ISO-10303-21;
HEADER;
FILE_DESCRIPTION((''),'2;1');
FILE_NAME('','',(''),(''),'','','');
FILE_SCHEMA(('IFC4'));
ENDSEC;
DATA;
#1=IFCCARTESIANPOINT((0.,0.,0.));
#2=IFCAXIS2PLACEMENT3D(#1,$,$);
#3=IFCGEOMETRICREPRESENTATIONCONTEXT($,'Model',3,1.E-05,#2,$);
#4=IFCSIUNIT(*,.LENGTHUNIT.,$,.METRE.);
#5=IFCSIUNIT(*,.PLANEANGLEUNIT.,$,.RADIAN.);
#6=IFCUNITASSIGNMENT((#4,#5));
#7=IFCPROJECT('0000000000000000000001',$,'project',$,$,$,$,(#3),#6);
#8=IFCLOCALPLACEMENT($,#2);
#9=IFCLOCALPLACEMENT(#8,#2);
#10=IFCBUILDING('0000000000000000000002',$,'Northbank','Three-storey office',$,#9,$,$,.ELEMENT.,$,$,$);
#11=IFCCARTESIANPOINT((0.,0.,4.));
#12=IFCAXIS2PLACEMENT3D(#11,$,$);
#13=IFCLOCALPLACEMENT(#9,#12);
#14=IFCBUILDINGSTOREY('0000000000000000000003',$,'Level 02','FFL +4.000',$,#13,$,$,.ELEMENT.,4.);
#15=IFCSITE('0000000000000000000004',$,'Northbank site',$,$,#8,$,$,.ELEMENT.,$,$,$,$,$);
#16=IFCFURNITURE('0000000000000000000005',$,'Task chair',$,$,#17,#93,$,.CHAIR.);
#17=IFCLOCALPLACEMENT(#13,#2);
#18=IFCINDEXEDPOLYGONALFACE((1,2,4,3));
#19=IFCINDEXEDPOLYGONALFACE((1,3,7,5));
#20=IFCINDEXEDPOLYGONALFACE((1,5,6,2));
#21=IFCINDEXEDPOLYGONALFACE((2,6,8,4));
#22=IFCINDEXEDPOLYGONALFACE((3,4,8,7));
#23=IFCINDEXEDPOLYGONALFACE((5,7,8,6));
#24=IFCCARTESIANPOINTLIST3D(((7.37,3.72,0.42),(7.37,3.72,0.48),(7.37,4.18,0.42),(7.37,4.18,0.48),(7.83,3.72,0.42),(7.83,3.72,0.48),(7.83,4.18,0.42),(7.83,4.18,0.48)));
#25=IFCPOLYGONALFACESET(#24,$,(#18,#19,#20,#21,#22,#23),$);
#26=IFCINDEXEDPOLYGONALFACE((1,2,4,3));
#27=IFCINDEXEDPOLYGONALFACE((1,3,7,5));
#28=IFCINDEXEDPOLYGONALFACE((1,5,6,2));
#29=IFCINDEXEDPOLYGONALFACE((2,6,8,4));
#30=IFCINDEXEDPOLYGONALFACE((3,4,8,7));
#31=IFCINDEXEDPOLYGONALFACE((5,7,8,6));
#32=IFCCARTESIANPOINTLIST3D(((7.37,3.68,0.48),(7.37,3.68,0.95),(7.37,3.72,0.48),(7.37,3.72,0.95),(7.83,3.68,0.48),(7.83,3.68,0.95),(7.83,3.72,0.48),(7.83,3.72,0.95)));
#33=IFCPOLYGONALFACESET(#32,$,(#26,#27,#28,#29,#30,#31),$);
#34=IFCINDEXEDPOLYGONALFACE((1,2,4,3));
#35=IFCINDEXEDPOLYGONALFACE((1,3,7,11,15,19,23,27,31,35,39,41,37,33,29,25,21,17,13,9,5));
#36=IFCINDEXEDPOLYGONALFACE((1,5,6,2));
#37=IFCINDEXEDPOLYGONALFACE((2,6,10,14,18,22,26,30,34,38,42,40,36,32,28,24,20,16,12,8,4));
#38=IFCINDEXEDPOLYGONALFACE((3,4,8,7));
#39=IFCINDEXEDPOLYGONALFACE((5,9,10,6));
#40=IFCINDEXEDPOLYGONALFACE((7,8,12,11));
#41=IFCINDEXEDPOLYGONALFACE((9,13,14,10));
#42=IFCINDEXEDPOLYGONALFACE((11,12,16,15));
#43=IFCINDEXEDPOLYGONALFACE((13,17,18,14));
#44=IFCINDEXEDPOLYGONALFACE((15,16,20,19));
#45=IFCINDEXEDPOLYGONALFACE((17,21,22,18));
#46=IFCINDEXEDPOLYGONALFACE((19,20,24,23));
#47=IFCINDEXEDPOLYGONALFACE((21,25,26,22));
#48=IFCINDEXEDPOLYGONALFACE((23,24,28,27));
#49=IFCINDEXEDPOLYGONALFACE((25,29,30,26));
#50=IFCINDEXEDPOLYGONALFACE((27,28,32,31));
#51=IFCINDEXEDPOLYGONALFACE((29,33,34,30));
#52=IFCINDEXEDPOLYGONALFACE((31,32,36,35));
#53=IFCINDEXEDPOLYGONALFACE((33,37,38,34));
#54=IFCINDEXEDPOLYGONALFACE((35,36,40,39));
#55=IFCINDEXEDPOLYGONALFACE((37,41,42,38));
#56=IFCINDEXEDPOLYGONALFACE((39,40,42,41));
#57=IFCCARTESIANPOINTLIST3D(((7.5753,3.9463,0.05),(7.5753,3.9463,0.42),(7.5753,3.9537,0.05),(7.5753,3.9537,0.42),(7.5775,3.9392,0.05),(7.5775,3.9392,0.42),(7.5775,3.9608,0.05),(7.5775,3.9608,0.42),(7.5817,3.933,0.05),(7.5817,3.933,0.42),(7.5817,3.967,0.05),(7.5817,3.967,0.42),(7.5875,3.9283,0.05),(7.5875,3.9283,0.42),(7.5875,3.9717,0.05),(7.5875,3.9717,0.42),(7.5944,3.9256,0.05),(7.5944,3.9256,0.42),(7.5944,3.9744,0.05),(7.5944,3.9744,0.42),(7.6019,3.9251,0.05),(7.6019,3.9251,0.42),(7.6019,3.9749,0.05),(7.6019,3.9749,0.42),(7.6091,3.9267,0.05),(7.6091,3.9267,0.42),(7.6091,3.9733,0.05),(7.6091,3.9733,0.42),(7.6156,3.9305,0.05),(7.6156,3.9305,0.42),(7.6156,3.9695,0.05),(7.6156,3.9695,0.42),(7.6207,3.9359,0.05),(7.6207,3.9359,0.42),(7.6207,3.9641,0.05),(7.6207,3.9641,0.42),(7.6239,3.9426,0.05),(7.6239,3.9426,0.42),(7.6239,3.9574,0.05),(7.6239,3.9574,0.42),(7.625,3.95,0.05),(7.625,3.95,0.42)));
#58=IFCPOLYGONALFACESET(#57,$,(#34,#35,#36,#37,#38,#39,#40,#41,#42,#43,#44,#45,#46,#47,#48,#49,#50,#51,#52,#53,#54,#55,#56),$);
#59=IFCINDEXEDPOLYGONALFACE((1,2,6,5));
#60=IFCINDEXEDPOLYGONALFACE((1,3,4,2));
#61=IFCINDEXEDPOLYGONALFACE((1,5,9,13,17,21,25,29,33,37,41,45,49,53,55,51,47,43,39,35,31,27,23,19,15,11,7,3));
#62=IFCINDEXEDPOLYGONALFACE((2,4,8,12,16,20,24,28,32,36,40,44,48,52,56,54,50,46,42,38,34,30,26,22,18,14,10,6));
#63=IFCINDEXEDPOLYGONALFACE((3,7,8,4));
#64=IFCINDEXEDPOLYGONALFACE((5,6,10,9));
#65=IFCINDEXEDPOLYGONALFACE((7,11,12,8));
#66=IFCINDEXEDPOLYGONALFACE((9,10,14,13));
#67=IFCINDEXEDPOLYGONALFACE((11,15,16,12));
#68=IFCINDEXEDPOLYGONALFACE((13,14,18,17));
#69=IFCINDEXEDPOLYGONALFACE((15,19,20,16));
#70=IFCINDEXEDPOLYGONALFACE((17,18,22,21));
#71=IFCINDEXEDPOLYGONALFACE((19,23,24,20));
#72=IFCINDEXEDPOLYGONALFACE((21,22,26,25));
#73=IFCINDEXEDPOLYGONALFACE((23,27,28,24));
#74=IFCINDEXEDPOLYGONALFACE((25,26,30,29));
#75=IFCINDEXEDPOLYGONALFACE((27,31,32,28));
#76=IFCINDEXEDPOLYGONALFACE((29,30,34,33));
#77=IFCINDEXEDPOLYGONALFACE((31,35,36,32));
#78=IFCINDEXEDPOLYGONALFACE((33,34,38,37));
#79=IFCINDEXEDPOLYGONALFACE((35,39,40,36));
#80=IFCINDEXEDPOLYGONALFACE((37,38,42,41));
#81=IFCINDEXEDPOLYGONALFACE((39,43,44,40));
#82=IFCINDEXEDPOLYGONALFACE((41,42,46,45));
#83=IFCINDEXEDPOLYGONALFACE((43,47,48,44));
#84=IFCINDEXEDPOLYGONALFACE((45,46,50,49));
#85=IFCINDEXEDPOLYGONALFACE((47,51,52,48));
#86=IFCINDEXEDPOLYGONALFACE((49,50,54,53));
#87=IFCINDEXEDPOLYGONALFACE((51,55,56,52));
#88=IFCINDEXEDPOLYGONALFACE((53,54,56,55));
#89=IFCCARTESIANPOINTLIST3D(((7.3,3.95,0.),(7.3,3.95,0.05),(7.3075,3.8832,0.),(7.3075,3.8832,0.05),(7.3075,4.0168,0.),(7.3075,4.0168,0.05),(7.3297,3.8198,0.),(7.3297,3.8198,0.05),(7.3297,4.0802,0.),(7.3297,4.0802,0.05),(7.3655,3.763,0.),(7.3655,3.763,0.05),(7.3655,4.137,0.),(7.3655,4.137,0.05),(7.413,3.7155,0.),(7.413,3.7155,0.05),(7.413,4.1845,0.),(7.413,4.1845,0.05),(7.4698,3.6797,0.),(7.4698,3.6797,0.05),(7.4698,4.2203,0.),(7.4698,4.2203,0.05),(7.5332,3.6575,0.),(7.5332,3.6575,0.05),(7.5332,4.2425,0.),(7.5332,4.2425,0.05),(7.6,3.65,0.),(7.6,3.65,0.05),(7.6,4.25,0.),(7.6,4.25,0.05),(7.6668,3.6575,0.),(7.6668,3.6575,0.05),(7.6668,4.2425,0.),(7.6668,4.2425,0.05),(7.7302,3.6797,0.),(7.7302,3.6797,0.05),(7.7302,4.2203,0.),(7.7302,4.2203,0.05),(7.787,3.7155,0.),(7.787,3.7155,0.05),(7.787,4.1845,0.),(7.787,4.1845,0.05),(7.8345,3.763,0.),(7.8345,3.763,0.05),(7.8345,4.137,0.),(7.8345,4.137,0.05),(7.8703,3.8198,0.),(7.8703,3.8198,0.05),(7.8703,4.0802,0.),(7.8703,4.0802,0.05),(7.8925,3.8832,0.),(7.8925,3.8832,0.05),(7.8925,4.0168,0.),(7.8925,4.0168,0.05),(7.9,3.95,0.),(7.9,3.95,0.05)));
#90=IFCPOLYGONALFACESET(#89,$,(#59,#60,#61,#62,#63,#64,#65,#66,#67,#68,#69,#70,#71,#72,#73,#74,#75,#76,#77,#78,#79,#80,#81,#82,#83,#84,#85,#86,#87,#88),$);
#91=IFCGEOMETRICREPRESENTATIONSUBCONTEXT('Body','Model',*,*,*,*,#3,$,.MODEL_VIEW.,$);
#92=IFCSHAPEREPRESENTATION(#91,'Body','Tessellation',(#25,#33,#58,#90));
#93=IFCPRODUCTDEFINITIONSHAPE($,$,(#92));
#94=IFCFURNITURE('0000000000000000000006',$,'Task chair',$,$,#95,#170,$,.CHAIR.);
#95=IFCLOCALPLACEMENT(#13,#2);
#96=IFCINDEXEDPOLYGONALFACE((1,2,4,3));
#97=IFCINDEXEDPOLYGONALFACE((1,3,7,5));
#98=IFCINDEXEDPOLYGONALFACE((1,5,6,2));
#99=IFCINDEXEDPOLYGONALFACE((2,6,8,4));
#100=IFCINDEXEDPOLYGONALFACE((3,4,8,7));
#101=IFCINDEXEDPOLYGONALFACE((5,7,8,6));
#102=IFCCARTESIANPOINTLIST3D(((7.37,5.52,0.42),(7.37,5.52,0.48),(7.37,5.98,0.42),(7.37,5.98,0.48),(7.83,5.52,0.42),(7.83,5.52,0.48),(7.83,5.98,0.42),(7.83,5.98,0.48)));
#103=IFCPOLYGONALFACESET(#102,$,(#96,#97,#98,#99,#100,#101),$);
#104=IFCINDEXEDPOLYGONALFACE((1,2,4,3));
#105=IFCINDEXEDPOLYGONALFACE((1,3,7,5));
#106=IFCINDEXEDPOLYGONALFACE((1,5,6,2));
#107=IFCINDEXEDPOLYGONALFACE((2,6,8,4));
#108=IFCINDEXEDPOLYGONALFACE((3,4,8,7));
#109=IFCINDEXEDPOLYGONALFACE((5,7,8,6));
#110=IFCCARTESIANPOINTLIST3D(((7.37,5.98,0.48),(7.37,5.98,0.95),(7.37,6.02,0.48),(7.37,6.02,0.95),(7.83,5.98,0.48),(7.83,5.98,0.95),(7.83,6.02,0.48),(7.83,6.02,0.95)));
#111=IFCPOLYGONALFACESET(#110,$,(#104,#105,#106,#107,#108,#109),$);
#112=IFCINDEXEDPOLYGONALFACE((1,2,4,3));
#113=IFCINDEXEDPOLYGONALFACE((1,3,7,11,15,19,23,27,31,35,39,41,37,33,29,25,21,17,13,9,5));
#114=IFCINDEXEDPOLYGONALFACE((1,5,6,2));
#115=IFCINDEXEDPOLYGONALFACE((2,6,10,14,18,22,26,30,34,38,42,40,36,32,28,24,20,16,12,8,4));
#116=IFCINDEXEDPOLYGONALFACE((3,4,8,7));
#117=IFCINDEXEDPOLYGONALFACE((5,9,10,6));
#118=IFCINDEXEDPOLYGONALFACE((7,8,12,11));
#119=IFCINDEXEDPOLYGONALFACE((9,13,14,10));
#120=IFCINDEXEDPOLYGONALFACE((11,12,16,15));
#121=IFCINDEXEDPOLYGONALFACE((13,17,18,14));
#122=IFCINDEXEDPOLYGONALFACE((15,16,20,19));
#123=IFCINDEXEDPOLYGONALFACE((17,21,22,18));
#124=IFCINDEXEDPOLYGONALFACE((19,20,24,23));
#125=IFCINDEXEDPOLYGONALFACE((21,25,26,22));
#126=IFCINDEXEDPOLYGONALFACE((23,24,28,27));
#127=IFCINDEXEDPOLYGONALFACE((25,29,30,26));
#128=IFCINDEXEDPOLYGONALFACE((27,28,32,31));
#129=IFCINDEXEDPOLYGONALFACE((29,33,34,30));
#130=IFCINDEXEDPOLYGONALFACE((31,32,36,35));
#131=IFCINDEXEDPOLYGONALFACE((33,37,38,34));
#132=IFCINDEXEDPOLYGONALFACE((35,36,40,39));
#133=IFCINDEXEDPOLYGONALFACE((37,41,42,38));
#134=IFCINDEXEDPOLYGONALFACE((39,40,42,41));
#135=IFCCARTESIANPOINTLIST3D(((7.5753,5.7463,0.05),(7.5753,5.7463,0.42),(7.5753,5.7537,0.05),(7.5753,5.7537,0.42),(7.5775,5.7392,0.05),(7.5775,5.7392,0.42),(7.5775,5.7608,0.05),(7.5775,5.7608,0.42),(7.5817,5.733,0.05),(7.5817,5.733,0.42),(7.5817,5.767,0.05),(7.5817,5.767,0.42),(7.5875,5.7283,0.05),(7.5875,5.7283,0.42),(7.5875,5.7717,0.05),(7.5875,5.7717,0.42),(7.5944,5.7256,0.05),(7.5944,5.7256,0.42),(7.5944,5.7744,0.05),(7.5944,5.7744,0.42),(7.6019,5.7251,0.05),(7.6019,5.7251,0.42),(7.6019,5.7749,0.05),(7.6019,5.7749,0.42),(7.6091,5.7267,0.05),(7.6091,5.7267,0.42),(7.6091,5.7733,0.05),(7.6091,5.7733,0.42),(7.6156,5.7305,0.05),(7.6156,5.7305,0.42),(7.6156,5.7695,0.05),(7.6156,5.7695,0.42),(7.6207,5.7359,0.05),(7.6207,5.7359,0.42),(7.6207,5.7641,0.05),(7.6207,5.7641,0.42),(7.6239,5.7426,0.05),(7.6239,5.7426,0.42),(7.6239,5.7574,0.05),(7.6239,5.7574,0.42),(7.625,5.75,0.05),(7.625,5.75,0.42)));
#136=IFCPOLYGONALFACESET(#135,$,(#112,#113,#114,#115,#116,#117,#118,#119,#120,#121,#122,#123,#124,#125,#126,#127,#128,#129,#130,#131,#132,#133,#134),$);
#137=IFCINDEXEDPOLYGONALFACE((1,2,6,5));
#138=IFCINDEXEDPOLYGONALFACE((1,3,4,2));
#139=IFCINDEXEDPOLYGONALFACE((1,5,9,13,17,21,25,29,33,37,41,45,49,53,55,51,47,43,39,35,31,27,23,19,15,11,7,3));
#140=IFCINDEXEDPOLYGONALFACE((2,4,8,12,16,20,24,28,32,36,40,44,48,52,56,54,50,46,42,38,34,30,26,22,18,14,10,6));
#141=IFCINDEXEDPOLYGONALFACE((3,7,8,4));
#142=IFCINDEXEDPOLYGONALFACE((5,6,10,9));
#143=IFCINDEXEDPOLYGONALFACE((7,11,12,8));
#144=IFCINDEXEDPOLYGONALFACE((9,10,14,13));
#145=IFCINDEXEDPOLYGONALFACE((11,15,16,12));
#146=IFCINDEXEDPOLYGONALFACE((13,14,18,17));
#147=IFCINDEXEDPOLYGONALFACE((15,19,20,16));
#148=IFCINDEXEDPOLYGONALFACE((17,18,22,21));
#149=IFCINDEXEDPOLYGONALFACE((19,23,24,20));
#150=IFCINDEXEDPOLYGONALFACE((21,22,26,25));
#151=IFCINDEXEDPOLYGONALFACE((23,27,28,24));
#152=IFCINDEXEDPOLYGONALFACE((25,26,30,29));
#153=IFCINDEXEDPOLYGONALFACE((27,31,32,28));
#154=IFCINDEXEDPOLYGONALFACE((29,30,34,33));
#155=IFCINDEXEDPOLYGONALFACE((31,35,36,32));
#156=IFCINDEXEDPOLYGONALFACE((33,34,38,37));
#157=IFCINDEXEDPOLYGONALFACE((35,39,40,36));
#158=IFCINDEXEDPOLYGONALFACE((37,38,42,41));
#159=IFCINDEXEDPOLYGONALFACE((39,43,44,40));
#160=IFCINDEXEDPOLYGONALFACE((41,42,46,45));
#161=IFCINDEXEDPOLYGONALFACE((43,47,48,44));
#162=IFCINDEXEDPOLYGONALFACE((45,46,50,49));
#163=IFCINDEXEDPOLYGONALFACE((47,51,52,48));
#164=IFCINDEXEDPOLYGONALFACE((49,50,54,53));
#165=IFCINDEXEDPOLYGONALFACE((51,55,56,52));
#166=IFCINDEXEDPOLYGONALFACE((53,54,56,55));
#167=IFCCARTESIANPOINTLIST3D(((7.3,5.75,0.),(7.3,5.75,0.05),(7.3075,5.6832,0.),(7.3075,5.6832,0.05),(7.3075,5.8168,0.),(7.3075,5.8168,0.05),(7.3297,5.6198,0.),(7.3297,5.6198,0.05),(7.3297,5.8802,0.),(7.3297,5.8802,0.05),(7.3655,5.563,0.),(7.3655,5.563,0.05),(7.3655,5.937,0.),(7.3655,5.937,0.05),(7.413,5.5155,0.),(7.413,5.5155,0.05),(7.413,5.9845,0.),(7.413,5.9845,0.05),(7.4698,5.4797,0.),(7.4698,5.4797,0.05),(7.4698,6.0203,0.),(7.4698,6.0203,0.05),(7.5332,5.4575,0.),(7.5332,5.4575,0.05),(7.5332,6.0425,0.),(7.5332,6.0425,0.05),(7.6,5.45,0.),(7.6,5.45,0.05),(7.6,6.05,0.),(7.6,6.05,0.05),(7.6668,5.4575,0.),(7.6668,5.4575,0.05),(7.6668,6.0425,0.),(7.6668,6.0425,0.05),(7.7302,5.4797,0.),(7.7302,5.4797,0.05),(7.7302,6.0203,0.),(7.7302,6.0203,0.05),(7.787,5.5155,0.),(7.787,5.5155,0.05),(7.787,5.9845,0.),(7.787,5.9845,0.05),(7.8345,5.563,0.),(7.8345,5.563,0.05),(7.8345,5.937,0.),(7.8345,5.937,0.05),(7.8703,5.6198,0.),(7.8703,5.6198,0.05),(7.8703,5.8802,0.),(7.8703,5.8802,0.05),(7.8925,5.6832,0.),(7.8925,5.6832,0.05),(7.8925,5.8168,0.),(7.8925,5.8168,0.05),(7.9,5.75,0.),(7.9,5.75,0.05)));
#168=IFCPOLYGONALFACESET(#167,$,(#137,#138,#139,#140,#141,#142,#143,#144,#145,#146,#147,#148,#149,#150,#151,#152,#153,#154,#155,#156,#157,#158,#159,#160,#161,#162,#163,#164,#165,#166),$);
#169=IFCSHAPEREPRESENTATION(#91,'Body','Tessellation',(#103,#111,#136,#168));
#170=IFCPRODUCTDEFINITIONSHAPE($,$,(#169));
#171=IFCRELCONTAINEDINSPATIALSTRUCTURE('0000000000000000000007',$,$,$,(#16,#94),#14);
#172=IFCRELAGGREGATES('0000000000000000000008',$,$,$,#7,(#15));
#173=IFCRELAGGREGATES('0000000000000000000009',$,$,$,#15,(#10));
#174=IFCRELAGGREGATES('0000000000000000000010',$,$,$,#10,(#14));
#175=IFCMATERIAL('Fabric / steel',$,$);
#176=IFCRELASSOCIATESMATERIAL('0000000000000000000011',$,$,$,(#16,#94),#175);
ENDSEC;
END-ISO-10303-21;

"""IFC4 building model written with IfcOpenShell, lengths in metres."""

from ifc_helpers import new_model, si_unit, frame, origin, place, context, subcontext, project, spatial, rectangle, circle, extrude, material, element, save


model = new_model("IFC4")

# Units and contexts
model_context = context("Model", 3, precision=1e-05, world=origin())
body_context = subcontext(model_context, "Body", "Model", "MODEL_VIEW")
ifc_project = project(units=[si_unit("LENGTHUNIT", "METRE"), si_unit("PLANEANGLEUNIT", "RADIAN")], contexts=[model_context])

# Site, building, storey
site_placement = place(None, origin())
site = spatial("IfcSite", under=ifc_project, at=site_placement, Name="Northbank site", CompositionType="ELEMENT")
building_placement = place(site_placement, origin())
building = spatial("IfcBuilding", under=site, at=building_placement, Name="Northbank", Description="Three-storey office", CompositionType="ELEMENT")
storey_placement = place(building_placement, frame((0.0, 0.0, 4.0)))
storey = spatial("IfcBuildingStorey", under=building, at=storey_placement, Name="Level 02", Description="FFL +4.000", CompositionType="ELEMENT", Elevation=4.0)

# Furniture
ifc_material_1 = material(Name="Fabric / steel")
furniture_1_placement = place(storey_placement, frame((0.0, 0.0, -4.0)))
element("IfcFurniture", 1, at=furniture_1_placement, inside=storey, material=ifc_material_1, Name="Task chair", PredefinedType="CHAIR", context=body_context, shape_type="SweptSolid", body=[
    extrude(rectangle(XDim=0.46, YDim=0.46), frame((7.6, 3.95, 4.42)), (0.0, 0.0, 1.0), 0.06),
    extrude(rectangle(XDim=0.46, YDim=0.04), frame((7.6, 3.7, 4.48)), (0.0, 0.0, 1.0), 0.47),
    extrude(circle(Radius=0.025), frame((7.6, 3.95, 4.05), z_axis=(0.0, 0.0, 1.0), x_axis=(1.0, 0.0, 0.0)), (0.0, 0.0, 1.0), 0.37),
    extrude(circle(Radius=0.3), frame((7.6, 3.95, 4.0), z_axis=(0.0, 0.0, 1.0), x_axis=(1.0, 0.0, 0.0)), (0.0, 0.0, 1.0), 0.05),
])
furniture_2_placement = place(storey_placement, frame((0.0, 0.0, -4.0)))
element("IfcFurniture", 2, at=furniture_2_placement, inside=storey, material=ifc_material_1, Name="Task chair", PredefinedType="CHAIR", context=body_context, shape_type="SweptSolid", body=[
    extrude(rectangle(XDim=0.46, YDim=0.46), frame((7.6, 5.75, 4.42)), (0.0, 0.0, 1.0), 0.06),
    extrude(rectangle(XDim=0.46, YDim=0.04), frame((7.6, 6.0, 4.48)), (0.0, 0.0, 1.0), 0.47),
    extrude(circle(Radius=0.025), frame((7.6, 5.75, 4.05), z_axis=(0.0, 0.0, 1.0), x_axis=(1.0, 0.0, 0.0)), (0.0, 0.0, 1.0), 0.37),
    extrude(circle(Radius=0.3), frame((7.6, 5.75, 4.0), z_axis=(0.0, 0.0, 1.0), x_axis=(1.0, 0.0, 0.0)), (0.0, 0.0, 1.0), 0.05),
])

save(model, "model.ifc")
